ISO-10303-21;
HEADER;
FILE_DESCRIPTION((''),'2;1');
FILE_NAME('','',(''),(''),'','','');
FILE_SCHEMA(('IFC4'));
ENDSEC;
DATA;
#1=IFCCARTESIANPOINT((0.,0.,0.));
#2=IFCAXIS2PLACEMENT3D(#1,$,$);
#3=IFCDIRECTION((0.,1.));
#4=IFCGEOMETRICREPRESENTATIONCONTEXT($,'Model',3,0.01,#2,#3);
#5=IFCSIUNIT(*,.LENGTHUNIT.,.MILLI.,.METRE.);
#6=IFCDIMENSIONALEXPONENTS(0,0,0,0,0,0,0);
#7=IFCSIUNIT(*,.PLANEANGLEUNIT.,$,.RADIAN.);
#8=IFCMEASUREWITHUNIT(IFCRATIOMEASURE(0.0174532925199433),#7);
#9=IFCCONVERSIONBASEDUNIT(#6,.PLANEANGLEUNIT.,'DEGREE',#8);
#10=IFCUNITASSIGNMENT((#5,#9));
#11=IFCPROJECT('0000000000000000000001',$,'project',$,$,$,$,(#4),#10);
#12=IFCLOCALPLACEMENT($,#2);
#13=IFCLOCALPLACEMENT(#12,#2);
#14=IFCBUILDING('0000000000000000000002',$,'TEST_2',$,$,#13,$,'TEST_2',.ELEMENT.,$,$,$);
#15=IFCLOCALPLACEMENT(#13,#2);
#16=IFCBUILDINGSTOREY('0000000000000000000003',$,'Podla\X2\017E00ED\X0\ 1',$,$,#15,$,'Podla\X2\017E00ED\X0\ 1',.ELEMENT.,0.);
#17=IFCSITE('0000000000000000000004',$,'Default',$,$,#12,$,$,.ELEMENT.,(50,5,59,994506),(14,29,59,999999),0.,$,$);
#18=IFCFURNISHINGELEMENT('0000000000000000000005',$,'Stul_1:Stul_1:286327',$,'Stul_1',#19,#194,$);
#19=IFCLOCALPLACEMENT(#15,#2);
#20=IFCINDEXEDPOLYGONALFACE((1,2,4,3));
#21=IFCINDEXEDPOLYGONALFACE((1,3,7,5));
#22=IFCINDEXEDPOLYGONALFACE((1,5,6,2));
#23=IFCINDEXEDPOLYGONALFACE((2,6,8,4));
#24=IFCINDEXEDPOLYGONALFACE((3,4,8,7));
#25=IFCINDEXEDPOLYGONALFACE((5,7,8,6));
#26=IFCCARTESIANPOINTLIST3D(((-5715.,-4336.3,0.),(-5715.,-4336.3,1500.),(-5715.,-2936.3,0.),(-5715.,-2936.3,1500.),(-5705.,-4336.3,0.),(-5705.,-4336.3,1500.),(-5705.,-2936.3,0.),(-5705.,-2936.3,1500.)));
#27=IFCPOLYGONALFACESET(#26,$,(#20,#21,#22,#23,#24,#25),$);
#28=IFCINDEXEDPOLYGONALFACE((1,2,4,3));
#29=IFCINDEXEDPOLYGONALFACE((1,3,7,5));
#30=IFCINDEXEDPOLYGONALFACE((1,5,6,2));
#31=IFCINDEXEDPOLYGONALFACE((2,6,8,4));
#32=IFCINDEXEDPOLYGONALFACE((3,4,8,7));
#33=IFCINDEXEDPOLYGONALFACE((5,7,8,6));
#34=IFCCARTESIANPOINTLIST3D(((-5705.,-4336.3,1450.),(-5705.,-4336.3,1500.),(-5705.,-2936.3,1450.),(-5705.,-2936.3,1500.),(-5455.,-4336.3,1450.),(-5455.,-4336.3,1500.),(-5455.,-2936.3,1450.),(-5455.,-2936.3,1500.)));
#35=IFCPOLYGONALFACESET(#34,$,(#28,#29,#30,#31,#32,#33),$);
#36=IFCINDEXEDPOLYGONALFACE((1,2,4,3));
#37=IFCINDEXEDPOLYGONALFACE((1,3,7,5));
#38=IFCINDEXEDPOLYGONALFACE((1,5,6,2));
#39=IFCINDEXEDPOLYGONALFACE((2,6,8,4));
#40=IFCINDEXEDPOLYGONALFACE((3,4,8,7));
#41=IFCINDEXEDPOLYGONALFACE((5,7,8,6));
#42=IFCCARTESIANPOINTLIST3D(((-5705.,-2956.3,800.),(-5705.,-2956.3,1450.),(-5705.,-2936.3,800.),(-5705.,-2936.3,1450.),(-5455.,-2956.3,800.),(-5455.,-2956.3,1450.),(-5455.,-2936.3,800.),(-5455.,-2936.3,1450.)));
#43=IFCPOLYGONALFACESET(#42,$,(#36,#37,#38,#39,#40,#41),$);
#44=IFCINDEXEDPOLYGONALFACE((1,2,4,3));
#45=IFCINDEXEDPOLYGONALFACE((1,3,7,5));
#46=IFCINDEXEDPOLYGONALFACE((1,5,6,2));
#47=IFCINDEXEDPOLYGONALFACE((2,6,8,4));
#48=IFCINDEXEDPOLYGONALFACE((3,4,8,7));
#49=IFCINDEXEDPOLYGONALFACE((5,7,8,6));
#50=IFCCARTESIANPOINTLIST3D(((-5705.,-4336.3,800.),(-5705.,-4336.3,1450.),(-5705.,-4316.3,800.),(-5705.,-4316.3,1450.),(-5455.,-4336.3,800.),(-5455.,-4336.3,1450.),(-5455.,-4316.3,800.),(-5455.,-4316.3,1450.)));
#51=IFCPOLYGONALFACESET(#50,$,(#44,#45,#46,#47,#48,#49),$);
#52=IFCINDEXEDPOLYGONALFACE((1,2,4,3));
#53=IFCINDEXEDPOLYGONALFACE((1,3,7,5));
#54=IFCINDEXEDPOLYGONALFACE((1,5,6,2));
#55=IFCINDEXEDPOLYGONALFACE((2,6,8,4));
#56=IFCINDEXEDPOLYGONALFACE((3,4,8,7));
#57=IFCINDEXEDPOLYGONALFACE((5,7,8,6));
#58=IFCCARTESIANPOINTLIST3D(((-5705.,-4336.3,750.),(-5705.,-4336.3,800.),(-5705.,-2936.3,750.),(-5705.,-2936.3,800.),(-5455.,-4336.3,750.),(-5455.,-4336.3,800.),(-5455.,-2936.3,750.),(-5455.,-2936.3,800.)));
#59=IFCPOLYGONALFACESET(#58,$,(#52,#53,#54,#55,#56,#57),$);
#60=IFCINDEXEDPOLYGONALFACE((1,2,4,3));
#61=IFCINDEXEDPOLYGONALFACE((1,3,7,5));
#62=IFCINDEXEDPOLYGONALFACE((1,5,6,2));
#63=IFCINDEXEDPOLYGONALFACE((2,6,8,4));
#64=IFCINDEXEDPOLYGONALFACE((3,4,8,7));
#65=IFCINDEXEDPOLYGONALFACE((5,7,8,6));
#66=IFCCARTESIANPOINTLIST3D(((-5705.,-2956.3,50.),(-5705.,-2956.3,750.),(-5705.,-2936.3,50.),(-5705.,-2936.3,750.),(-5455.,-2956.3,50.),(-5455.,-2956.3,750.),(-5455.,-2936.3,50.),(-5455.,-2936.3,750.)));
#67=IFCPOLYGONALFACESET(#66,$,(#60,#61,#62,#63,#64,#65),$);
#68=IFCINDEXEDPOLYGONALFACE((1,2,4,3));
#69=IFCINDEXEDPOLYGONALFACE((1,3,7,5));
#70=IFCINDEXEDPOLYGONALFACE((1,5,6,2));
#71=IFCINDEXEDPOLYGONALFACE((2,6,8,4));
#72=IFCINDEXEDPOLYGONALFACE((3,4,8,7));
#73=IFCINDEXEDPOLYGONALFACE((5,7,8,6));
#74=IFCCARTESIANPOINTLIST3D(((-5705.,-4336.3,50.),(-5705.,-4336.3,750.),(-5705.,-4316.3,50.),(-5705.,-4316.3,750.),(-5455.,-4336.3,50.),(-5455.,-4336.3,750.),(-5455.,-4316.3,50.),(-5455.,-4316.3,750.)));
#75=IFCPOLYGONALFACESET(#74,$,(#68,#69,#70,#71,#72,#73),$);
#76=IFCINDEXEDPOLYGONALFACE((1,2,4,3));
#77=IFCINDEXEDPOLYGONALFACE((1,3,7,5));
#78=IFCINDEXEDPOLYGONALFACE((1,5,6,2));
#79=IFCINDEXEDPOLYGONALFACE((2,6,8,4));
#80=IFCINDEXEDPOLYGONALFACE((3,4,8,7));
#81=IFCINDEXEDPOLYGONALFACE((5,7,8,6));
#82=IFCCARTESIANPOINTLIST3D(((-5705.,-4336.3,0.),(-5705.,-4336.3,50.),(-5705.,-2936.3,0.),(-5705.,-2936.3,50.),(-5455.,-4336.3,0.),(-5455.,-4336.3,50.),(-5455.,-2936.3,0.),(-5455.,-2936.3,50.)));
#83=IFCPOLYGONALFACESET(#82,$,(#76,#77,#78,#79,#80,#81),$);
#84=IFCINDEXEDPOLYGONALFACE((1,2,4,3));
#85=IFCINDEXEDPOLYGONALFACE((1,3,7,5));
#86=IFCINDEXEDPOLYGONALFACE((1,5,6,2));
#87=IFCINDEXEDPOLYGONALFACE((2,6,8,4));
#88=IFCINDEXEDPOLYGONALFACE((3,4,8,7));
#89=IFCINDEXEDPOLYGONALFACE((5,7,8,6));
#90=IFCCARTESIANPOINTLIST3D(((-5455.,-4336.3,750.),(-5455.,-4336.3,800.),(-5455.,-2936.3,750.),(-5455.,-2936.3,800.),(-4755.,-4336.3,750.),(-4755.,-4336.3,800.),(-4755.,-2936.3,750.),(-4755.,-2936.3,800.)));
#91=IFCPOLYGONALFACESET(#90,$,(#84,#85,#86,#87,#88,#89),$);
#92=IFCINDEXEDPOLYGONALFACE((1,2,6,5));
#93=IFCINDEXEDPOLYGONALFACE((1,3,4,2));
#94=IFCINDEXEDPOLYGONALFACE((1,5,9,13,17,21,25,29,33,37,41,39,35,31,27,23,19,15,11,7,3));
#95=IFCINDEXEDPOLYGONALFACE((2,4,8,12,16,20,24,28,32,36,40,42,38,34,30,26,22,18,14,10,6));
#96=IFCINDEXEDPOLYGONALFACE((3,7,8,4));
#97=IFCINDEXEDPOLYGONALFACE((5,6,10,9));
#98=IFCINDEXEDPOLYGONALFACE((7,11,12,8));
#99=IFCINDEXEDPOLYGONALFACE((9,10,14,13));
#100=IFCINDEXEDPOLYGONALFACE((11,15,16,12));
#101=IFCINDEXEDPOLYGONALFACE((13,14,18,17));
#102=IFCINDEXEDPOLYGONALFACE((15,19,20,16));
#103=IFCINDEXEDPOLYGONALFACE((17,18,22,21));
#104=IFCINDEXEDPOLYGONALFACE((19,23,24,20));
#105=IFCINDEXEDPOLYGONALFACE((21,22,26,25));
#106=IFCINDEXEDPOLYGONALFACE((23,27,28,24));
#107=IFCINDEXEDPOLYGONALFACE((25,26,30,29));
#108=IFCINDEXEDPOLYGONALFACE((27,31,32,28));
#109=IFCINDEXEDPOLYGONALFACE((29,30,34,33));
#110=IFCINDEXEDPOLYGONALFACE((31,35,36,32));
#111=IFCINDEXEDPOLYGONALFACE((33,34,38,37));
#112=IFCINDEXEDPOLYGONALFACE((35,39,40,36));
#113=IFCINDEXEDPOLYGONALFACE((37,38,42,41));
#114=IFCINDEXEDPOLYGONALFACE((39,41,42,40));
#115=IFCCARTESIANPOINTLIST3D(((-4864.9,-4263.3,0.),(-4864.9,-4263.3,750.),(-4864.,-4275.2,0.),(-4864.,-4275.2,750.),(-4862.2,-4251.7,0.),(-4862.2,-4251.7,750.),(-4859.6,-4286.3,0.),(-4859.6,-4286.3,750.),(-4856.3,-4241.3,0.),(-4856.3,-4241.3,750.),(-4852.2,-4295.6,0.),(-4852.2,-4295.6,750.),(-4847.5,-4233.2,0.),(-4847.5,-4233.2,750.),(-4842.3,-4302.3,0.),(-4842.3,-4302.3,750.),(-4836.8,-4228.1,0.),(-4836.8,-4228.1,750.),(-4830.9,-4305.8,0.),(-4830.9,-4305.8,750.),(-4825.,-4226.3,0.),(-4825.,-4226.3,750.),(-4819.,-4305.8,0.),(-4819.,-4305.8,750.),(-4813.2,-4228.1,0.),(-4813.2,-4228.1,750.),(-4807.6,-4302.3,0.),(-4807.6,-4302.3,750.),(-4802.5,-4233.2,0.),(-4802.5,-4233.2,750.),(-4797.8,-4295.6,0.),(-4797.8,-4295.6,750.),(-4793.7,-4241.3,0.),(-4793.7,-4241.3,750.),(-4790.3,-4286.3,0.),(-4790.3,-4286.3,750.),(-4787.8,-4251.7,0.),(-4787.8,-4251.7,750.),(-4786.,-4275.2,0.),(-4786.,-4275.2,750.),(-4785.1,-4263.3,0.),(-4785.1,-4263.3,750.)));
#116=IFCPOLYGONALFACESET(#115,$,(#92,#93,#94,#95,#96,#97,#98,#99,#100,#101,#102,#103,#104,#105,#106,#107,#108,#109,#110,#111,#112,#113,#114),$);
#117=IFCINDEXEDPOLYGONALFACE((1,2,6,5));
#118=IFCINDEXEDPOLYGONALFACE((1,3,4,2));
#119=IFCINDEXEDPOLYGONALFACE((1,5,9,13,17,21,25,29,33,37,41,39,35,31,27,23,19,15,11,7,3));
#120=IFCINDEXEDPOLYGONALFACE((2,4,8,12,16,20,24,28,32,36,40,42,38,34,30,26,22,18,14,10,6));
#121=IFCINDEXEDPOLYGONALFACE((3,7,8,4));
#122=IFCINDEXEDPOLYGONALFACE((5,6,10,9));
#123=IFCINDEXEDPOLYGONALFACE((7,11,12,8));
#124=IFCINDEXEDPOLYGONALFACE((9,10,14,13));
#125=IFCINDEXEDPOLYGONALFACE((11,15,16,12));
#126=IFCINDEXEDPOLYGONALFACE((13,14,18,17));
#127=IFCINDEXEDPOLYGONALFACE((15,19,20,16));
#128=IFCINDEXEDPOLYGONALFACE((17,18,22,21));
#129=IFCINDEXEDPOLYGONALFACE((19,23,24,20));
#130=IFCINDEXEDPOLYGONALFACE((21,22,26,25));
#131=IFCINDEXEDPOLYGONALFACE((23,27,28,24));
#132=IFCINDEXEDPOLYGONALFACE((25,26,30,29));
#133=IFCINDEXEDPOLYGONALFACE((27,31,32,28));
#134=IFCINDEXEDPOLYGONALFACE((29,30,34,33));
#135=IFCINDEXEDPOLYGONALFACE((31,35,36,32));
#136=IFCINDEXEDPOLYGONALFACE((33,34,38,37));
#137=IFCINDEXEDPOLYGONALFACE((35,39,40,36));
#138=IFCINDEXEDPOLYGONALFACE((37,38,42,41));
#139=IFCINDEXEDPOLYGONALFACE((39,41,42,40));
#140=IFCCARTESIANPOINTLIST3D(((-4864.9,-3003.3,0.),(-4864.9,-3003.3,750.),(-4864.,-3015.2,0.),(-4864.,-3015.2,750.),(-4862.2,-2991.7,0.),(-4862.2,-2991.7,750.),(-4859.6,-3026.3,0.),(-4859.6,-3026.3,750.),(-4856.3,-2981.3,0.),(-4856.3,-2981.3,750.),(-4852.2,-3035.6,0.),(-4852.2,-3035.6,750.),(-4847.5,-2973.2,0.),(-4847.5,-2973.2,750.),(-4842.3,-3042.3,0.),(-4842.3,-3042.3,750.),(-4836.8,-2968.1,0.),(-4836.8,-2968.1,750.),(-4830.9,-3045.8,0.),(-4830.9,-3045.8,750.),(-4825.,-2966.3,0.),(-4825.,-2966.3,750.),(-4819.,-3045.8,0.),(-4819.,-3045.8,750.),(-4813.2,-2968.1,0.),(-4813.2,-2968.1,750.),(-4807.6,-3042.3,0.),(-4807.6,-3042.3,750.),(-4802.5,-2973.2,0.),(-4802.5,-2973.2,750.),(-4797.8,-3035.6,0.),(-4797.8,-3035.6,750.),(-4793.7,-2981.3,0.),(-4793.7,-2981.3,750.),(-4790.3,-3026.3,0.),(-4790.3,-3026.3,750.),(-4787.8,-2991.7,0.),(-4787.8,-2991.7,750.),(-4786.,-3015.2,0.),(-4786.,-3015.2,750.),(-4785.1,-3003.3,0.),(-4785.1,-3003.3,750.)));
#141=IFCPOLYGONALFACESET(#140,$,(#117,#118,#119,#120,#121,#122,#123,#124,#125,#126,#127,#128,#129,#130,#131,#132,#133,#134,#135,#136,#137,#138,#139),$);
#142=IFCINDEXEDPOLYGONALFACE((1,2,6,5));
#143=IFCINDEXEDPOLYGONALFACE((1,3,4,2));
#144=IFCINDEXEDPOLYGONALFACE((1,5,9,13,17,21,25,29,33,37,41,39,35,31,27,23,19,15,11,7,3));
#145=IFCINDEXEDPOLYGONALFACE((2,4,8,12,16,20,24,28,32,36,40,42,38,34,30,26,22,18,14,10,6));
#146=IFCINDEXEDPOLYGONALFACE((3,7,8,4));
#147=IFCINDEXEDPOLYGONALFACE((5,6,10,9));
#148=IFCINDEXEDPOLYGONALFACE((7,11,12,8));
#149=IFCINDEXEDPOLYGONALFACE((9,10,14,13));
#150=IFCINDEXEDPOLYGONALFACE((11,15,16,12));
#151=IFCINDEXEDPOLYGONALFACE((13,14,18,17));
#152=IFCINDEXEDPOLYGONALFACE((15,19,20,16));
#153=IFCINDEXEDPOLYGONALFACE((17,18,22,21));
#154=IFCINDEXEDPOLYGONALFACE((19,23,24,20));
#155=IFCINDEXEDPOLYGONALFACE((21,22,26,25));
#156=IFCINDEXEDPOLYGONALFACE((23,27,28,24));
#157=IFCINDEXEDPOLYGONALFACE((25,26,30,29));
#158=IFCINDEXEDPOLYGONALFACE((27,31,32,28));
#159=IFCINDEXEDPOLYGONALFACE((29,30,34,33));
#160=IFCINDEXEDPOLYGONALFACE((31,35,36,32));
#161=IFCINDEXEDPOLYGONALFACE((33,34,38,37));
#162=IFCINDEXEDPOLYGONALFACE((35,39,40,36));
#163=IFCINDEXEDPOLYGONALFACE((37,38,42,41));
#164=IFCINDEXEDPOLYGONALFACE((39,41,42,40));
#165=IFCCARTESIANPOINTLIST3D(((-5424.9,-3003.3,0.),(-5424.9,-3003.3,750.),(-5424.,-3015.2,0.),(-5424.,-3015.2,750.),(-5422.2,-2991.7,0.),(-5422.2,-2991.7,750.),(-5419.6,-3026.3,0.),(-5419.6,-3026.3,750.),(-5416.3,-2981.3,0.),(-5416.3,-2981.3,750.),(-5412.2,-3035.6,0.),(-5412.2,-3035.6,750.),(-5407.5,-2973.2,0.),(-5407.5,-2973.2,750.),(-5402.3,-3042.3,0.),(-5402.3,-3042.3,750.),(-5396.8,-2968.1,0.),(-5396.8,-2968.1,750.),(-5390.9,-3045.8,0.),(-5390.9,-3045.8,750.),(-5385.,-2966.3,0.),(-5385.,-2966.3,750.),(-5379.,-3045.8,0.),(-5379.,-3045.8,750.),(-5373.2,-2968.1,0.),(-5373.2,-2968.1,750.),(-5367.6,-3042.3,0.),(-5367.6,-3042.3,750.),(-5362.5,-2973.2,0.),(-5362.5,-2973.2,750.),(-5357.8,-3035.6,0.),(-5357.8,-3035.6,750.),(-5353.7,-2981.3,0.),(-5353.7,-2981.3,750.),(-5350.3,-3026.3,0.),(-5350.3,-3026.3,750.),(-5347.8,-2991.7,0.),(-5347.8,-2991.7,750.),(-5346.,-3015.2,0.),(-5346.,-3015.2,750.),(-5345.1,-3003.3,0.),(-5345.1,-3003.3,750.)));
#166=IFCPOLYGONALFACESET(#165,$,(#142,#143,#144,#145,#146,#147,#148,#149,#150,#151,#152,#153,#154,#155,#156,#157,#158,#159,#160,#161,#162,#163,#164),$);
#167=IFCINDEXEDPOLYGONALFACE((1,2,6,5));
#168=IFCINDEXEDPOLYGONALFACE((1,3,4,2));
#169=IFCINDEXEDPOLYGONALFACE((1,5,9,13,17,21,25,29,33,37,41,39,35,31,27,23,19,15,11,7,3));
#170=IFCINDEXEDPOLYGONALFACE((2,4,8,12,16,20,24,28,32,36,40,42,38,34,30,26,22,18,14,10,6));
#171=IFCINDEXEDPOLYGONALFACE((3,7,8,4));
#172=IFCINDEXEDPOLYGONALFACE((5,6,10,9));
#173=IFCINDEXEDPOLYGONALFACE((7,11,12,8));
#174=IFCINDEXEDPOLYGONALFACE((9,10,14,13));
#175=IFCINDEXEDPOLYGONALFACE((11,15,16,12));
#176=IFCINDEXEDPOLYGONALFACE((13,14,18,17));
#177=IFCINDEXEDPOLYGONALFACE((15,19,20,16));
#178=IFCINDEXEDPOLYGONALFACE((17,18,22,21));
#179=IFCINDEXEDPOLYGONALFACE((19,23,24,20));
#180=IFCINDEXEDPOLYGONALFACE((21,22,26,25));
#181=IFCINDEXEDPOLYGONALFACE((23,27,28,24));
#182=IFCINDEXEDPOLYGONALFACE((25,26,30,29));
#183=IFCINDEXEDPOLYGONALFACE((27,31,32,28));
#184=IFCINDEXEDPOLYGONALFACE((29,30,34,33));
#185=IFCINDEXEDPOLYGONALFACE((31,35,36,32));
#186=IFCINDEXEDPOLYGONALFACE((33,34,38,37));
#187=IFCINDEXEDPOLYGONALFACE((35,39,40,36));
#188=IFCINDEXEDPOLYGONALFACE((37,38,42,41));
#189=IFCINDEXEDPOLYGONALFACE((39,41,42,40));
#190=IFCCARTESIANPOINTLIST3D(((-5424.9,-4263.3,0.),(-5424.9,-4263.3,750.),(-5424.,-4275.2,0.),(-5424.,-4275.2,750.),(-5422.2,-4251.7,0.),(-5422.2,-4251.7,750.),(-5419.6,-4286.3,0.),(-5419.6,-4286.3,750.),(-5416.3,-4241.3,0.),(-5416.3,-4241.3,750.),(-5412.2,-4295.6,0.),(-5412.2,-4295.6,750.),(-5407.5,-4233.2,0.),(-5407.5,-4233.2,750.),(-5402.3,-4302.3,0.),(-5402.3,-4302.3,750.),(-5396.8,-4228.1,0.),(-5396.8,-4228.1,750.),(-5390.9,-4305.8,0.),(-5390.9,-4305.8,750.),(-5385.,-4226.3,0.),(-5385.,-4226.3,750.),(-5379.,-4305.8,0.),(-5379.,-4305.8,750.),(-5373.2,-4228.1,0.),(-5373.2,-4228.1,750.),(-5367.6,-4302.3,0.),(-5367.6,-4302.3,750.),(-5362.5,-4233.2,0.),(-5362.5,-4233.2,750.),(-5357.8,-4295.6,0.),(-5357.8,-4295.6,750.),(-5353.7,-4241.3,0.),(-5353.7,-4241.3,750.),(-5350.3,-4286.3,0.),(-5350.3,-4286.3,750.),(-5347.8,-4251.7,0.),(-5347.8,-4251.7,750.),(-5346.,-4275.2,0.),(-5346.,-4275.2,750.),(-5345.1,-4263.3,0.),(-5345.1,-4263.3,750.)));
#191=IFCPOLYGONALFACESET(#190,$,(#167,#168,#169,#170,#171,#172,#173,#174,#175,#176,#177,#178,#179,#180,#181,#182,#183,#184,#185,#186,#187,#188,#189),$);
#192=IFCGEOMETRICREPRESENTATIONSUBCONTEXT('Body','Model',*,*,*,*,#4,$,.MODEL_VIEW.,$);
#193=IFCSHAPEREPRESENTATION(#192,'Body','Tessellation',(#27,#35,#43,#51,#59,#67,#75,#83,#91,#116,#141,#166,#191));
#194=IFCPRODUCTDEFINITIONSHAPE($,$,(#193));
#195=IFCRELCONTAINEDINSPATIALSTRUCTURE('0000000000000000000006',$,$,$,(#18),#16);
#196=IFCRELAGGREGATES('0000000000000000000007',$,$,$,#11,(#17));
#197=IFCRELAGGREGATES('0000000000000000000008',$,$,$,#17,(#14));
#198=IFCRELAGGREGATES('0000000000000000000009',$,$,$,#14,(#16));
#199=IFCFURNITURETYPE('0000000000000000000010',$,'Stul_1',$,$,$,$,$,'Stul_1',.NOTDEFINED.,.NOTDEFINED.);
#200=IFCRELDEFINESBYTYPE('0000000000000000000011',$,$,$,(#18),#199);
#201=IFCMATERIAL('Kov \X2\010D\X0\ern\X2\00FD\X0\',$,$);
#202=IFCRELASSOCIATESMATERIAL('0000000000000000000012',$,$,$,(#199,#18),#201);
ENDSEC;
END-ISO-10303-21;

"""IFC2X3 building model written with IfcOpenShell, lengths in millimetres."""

from ifc_helpers import new_model, entity, si_unit, converted_unit, direction, frame, frame_2d, origin, origin_2d_with_axis, place, context, subcontext, project, spatial, rectangle, circle, extrude, source, transform, mapped, material, type_object, type_shapes, element, save


model = new_model("IFC2X3")

# Units and contexts
model_context = context("Model", 3, precision=0.01, world=origin(), true_north=direction((0.0, 1.0)))
body_context = subcontext(model_context, "Body", "Model", "MODEL_VIEW")
ifc_project = project(units=[si_unit("LENGTHUNIT", "METRE", prefix="MILLI"), converted_unit("PLANEANGLEUNIT", "DEGREE", entity("IfcRatioMeasure", 0.0174532925199433), si_unit("PLANEANGLEUNIT", "RADIAN"), dimensions=[0, 0, 0, 0, 0, 0, 0])], contexts=[model_context])

# Site, building, storey
site_placement = place(None, origin())
site = spatial("IfcSite", under=ifc_project, at=site_placement, Name="Default", CompositionType="ELEMENT", RefLatitude=(50, 5, 59, 994506), RefLongitude=(14, 29, 59, 999999), RefElevation=0.0)
building_placement = place(site_placement, origin())
building = spatial("IfcBuilding", under=site, at=building_placement, Name="TEST_2", LongName="TEST_2", CompositionType="ELEMENT")
storey_placement = place(building_placement, origin())
storey = spatial("IfcBuildingStorey", under=building, at=storey_placement, Name="Podlaží 1", LongName="Podlaží 1", CompositionType="ELEMENT", Elevation=0.0)

# Furnishing element
ifc_material_1 = material(Name="Kov černý")
furniture_type = type_object("IfcFurnitureType", Name="Stul_1", ElementType="Stul_1", material=ifc_material_1)
shared_shape_1 = source(origin(), body_context, "Body", "SweptSolid", [
    extrude(rectangle(XDim=1400.0, YDim=10.0, at=origin_2d_with_axis()), frame((0.0, 605.0, 0.0), z_axis=(0.0, 0.0, 1.0), x_axis=(-1.0, 0.0, 0.0)), (0.0, 0.0, 1.0), 1500.0),
    extrude(rectangle(XDim=1400.0, YDim=250.0, at=frame_2d((0.0, 0.0), x_axis=(1.0, 0.0))), frame((0.0, 475.0, 1450.0), z_axis=(0.0, 0.0, 1.0), x_axis=(-1.0, 0.0, 0.0)), (0.0, 0.0, 1.0), 50.0),
    extrude(rectangle(XDim=20.0, YDim=250.0, at=origin_2d_with_axis()), frame((690.0, 475.0, 800.0), z_axis=(0.0, 0.0, 1.0), x_axis=(-1.0, 0.0, 0.0)), (0.0, 0.0, 1.0), 650.0),
    extrude(rectangle(XDim=20.0, YDim=250.0, at=frame_2d((0.0, 0.0), x_axis=(1.0, 0.0))), frame((-690.0, 475.0, 800.0), z_axis=(0.0, 0.0, 1.0), x_axis=(-1.0, 0.0, 0.0)), (0.0, 0.0, 1.0), 650.0),
    extrude(rectangle(XDim=1400.0, YDim=250.0, at=origin_2d_with_axis()), frame((0.0, 475.0, 750.0), z_axis=(0.0, 0.0, 1.0), x_axis=(-1.0, 0.0, 0.0)), (0.0, 0.0, 1.0), 50.0),
    extrude(rectangle(XDim=20.0, YDim=250.0, at=origin_2d_with_axis()), frame((690.0, 475.0, 50.0), z_axis=(0.0, 0.0, 1.0), x_axis=(-1.0, 0.0, 0.0)), (0.0, 0.0, 1.0), 700.0),
    extrude(rectangle(XDim=20.0, YDim=250.0, at=frame_2d((0.0, 0.0), x_axis=(1.0, 0.0))), frame((-690.0, 475.0, 50.0), z_axis=(0.0, 0.0, 1.0), x_axis=(-1.0, 0.0, 0.0)), (0.0, 0.0, 1.0), 700.0),
    extrude(rectangle(XDim=1400.0, YDim=250.0, at=origin_2d_with_axis()), frame((0.0, 475.0, 0.0), z_axis=(0.0, 0.0, 1.0), x_axis=(-1.0, 0.0, 0.0)), (0.0, 0.0, 1.0), 50.0),
    extrude(rectangle(XDim=1400.0, YDim=700.0, at=origin_2d_with_axis()), frame((0.0, 0.0, 750.0), z_axis=(0.0, 0.0, 1.0), x_axis=(-1.0, 0.0, 0.0)), (0.0, 0.0, 1.0), 50.0),
    extrude(circle(Radius=40.0, at=frame_2d((0.0, 0.0), x_axis=(1.0, 0.0))), frame((-630.0, -280.0, 0.0)), (0.0, 0.0, 1.0), 750.0),
    extrude(circle(Radius=40.0, at=frame_2d((0.0, 0.0), x_axis=(1.0, 0.0))), frame((630.0, -280.0, 0.0)), (0.0, 0.0, 1.0), 750.0),
    extrude(circle(Radius=40.0, at=frame_2d((0.0, 0.0), x_axis=(1.0, 0.0))), frame((630.0, 280.0, 0.0)), (0.0, 0.0, 1.0), 750.0),
    extrude(circle(Radius=40.0, at=frame_2d((0.0, 0.0), x_axis=(1.0, 0.0))), frame((-630.0, 280.0, 0.0)), (0.0, 0.0, 1.0), 750.0),
])
type_shapes(furniture_type, [shared_shape_1])
for number, where, z_axis, x_axis, name in (
    (1, (-5105.0, -3636.3, 0.0), (0.0, 0.0, 1.0), (0.0, 1.0, 0.0), "Stul_1:Stul_1:286327"),
):
    element("IfcFurnishingElement", number, at=place(storey_placement, frame(where, z_axis=z_axis, x_axis=x_axis)), inside=storey, type_object=furniture_type, material=ifc_material_1, Name=name, ObjectType="Stul_1", context=body_context, shape_type="MappedRepresentation", body=[
        mapped(shared_shape_1, transform((0.0, 0.0, 0.0), scale=1.0)),
    ])

save(model, "model.ifc")
